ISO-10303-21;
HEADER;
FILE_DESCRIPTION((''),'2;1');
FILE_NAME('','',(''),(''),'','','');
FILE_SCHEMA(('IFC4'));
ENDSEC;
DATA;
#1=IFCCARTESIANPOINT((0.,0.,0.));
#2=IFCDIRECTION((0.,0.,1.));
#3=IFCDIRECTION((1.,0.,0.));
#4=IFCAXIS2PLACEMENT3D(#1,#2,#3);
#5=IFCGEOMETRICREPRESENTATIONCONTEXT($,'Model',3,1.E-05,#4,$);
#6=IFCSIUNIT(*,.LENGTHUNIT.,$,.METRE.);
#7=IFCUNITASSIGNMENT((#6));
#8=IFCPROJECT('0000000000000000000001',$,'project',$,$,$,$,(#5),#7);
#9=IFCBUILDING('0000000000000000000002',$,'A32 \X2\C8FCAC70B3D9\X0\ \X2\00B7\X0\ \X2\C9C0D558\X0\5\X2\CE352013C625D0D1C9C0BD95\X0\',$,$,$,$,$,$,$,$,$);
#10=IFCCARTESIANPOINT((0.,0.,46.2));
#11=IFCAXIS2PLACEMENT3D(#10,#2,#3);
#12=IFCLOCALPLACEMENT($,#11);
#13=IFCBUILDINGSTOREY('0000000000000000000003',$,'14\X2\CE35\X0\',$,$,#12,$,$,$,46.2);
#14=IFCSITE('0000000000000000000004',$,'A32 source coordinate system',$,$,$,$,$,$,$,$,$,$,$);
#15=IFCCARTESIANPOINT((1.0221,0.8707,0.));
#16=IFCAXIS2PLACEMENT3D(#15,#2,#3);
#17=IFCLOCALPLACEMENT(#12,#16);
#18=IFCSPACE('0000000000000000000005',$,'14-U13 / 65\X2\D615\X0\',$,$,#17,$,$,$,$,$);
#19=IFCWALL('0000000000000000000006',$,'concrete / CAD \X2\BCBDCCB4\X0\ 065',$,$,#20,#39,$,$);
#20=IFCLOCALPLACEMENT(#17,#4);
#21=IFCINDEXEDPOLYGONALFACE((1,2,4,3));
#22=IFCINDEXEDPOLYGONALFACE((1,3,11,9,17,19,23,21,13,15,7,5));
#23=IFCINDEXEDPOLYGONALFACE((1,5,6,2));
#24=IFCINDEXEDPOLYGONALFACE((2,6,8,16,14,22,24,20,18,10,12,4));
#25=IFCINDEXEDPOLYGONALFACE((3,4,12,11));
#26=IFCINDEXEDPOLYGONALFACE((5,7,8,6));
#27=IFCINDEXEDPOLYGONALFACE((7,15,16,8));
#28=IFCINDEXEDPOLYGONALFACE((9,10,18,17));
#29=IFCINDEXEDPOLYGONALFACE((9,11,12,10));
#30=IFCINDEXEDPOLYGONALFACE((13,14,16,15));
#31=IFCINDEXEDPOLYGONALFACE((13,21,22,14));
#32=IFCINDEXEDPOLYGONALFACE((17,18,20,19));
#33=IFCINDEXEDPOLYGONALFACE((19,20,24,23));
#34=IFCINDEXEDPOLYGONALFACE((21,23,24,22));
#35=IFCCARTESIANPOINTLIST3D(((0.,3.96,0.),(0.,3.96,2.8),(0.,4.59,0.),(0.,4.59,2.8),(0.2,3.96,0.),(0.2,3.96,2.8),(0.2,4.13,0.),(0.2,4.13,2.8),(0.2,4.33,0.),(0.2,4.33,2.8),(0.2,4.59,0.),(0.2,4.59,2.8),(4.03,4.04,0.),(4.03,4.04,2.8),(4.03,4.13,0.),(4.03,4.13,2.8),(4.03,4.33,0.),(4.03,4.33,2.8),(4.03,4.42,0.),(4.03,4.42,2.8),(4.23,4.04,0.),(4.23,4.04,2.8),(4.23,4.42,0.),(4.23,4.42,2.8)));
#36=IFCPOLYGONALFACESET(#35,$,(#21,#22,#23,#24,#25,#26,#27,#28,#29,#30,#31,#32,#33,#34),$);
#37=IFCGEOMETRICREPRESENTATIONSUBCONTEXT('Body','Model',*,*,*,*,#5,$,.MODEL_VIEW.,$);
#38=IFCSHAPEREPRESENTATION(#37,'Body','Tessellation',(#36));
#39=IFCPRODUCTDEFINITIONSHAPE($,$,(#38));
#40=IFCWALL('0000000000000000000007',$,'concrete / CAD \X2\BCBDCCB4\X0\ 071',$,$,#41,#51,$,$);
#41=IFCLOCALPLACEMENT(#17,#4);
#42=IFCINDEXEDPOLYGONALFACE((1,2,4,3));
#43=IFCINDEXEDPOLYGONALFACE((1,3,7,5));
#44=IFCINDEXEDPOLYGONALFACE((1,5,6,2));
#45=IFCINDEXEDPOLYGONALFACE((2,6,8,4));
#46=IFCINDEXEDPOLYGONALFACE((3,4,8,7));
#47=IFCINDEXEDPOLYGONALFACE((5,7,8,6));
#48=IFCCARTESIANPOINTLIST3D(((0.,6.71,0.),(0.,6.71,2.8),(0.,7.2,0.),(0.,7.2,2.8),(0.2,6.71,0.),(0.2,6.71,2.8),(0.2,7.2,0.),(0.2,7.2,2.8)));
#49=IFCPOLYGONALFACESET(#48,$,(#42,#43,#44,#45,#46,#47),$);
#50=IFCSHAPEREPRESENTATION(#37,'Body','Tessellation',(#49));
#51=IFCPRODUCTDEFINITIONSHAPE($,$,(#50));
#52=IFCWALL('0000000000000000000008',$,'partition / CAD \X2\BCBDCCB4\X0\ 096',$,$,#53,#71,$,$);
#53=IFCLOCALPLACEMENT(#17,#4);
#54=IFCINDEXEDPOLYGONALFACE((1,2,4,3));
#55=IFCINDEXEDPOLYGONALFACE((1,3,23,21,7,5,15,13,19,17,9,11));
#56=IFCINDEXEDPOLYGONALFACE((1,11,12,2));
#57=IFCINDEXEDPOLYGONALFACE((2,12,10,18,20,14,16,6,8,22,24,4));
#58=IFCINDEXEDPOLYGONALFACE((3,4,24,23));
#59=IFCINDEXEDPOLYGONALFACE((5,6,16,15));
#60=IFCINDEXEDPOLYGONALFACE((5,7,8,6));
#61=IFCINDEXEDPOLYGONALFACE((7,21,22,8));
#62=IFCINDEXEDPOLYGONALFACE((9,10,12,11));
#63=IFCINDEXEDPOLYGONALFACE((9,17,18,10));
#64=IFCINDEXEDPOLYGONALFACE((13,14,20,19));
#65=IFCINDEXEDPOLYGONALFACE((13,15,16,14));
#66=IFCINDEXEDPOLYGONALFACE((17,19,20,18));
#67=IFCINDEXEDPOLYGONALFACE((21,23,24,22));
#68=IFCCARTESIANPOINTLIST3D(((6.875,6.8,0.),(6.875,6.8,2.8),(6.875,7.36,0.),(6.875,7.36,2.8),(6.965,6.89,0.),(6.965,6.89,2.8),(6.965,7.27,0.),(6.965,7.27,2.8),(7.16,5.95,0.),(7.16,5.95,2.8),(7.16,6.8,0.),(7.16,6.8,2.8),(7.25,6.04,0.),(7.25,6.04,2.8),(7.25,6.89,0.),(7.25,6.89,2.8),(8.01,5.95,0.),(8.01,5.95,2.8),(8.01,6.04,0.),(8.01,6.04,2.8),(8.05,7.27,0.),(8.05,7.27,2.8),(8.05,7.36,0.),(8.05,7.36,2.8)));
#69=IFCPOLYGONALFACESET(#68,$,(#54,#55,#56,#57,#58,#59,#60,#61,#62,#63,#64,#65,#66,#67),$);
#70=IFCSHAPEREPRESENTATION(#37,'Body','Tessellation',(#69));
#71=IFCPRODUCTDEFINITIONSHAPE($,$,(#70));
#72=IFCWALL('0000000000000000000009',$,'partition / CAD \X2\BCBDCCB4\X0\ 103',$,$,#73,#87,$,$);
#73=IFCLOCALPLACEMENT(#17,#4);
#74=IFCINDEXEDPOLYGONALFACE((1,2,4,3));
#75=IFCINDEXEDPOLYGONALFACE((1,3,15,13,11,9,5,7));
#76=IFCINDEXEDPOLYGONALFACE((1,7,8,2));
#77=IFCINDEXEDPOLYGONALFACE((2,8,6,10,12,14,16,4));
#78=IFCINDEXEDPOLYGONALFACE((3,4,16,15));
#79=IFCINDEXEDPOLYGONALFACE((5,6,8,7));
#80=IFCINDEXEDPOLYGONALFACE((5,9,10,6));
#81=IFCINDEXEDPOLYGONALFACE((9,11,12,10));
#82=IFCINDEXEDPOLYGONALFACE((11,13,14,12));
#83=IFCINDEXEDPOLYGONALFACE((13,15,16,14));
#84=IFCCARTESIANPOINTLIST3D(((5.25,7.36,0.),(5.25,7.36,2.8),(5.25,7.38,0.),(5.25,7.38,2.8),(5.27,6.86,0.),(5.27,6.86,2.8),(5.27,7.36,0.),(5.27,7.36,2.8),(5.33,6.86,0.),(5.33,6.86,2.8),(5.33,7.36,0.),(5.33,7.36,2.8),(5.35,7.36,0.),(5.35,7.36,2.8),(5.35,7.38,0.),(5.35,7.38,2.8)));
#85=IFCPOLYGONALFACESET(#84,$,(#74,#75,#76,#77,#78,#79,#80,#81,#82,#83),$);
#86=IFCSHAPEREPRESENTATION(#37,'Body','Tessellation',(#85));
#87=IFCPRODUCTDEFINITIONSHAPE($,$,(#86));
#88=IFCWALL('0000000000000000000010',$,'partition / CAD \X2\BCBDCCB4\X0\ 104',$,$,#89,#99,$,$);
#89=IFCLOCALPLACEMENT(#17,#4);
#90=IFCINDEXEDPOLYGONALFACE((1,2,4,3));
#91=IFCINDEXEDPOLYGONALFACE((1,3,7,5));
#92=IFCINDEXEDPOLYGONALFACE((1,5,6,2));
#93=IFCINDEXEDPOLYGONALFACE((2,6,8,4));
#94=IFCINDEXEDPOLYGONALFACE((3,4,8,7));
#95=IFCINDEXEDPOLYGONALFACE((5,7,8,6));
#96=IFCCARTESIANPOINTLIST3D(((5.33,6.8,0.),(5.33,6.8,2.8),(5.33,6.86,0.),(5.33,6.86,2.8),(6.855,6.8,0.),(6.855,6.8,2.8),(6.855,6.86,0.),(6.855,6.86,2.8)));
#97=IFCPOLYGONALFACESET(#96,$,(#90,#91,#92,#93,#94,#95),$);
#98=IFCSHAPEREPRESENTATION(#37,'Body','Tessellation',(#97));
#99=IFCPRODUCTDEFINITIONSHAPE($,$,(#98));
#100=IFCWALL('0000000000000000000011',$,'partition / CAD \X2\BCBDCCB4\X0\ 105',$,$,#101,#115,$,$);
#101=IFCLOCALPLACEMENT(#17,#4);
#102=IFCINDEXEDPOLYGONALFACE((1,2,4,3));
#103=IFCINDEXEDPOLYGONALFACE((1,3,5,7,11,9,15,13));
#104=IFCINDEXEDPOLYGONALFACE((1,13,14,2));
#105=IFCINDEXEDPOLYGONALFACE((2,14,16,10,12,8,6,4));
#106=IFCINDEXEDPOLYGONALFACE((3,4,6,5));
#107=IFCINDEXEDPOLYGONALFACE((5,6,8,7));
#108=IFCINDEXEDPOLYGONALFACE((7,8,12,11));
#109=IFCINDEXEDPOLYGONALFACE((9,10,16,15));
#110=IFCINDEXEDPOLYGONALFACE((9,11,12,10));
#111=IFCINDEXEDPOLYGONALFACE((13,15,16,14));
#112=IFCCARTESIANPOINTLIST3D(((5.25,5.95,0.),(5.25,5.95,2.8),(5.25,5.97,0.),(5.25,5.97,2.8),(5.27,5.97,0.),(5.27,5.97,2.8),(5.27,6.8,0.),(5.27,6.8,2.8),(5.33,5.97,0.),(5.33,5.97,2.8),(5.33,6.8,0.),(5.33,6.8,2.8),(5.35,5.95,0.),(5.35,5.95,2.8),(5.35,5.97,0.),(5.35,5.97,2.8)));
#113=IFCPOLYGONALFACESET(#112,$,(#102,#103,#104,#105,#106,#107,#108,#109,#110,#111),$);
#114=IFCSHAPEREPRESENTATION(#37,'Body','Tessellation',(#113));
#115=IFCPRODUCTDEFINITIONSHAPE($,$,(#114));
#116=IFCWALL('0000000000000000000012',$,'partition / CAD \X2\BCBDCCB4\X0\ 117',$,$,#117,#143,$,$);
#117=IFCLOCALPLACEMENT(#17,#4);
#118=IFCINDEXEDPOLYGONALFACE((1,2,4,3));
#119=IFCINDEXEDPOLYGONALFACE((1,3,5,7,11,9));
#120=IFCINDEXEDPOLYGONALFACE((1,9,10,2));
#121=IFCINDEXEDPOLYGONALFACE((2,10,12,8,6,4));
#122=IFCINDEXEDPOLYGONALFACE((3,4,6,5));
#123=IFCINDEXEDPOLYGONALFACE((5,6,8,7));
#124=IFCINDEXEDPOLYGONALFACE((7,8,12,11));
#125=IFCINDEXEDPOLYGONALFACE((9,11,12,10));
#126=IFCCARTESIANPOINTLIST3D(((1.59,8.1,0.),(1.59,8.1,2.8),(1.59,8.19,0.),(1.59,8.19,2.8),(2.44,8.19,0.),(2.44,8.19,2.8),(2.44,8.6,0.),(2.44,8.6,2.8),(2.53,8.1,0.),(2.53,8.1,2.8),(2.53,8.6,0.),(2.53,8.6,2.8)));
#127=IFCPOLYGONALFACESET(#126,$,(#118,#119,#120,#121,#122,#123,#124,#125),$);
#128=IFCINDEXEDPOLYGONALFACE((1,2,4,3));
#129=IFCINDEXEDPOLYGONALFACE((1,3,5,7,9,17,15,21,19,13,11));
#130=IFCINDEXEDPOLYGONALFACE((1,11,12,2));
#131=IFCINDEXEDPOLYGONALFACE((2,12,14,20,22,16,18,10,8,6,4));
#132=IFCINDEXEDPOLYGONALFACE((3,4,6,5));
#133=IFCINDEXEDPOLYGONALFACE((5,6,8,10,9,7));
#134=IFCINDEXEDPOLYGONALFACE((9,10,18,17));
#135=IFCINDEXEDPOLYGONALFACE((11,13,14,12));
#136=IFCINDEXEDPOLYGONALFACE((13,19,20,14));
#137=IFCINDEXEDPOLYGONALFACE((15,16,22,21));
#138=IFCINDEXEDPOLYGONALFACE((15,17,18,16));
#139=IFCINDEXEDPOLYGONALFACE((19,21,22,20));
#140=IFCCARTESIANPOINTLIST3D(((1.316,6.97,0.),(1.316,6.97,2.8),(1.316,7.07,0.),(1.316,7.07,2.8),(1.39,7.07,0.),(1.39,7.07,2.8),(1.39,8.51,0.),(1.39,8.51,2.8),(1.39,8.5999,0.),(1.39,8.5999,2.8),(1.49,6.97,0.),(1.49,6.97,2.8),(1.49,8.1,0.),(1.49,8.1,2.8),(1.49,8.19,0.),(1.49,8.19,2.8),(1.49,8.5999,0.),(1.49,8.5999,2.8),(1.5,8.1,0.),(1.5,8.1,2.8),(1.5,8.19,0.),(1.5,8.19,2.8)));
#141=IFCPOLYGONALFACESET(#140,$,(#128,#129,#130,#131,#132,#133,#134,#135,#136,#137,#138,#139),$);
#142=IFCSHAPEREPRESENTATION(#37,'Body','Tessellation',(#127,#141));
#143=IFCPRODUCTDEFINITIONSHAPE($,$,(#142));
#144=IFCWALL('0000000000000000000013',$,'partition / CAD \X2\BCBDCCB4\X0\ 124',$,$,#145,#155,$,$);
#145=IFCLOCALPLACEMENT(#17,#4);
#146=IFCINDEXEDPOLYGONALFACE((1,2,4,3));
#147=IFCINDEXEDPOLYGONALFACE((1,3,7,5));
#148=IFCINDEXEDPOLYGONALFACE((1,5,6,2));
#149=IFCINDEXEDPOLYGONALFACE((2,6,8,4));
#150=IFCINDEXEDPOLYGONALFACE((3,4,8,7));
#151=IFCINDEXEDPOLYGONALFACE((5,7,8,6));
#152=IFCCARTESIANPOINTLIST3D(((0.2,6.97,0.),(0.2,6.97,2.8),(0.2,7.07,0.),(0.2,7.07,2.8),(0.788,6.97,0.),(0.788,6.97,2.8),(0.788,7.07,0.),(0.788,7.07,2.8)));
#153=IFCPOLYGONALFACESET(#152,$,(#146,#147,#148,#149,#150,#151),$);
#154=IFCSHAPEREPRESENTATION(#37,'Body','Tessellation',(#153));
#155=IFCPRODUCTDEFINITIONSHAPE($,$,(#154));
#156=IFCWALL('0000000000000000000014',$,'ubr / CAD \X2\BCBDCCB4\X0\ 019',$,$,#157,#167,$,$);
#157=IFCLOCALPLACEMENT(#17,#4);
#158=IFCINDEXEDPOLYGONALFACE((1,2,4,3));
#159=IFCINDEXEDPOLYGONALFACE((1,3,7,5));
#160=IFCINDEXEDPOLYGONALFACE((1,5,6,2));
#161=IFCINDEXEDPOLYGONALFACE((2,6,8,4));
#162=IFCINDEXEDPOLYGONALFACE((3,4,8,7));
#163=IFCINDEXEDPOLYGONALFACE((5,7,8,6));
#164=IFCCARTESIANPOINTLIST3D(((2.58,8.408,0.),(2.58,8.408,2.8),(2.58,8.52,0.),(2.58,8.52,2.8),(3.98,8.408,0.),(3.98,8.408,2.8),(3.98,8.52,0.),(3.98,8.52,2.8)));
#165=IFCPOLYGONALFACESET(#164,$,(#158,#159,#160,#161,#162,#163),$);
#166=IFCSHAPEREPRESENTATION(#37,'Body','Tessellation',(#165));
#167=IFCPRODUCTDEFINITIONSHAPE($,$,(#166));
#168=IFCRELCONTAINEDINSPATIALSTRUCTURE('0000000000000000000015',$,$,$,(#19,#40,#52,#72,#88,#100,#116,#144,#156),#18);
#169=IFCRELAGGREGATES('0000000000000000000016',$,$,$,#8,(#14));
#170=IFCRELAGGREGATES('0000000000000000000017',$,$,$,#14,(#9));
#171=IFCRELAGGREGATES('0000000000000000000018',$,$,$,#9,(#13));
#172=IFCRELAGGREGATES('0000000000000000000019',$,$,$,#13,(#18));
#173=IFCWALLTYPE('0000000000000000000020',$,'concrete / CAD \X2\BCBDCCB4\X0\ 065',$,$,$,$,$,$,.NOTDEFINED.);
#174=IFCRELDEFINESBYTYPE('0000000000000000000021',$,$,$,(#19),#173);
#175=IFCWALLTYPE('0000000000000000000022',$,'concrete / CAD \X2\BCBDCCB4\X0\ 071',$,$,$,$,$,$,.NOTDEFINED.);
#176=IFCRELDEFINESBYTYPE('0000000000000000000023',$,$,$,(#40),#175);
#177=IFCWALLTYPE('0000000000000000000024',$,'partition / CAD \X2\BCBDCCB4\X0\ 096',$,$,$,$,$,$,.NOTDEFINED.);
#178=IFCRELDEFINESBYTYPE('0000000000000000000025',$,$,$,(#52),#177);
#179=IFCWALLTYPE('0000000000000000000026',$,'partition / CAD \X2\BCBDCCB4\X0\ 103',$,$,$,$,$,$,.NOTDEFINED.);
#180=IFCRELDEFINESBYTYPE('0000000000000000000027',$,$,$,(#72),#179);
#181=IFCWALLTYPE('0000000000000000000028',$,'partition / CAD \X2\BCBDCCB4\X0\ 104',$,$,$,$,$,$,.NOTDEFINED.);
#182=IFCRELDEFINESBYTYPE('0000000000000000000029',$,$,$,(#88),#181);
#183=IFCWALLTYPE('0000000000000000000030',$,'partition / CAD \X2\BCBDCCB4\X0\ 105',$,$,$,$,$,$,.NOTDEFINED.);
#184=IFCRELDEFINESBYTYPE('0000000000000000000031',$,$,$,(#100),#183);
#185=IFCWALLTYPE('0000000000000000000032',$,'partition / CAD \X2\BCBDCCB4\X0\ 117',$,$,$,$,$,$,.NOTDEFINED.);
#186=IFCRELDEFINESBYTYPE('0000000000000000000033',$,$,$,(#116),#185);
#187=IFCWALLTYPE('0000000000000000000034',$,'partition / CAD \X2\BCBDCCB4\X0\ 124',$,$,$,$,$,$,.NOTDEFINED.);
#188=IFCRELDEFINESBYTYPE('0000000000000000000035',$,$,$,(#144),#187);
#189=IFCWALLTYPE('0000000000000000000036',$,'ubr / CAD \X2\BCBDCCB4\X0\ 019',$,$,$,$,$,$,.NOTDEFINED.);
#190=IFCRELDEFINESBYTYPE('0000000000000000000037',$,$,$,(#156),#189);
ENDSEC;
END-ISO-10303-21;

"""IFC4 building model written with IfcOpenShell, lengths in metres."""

from ifc_helpers import new_model, si_unit, frame, origin, origin_with_axes, place, context, subcontext, project, spatial, polyline, outline, extrude, source, transform, mapped, type_object, type_shapes, element, save


model = new_model("IFC4")

# Units and contexts
model_context = context("Model", 3, precision=1e-05, world=origin_with_axes())
body_context = subcontext(model_context, "Body", "Model", "MODEL_VIEW")
ifc_project = project(units=[si_unit("LENGTHUNIT", "METRE")], contexts=[model_context])

# Site, building, storey, space
storey_placement = place(None, frame((0.0, 0.0, 46.2), z_axis=(0.0, 0.0, 1.0), x_axis=(1.0, 0.0, 0.0)))
space_placement = place(storey_placement, frame((1.0221, 0.8707, 0.0), z_axis=(0.0, 0.0, 1.0), x_axis=(1.0, 0.0, 0.0)))
site = spatial("IfcSite", under=ifc_project, Name="A32 source coordinate system")
building = spatial("IfcBuilding", under=site, Name="A32 주거동 · 지하5층–옥탑지붕")
storey = spatial("IfcBuildingStorey", under=building, at=storey_placement, Name="14층", Elevation=46.2)
space = spatial("IfcSpace", under=storey, at=space_placement, Name="14-U13 / 65형")

# Walls
wall_type_1 = type_object("IfcWallType", Name="concrete / CAD 벽체 065", PredefinedType="NOTDEFINED")
shared_shape_1 = source(origin(), body_context, "Body", "SweptSolid", [
    extrude(outline(polyline([(0.2, 4.59), (0.2, 4.33), (4.03, 4.33), (4.03, 4.42), (4.23, 4.42), (4.23, 4.04), (4.03, 4.04), (4.03, 4.13), (0.2, 4.13), (0.2, 3.96), (0.0, 3.96), (0.0, 4.59), (0.2, 4.59)])), origin(), (0.0, 0.0, 1.0), 2.8),
])
type_shapes(wall_type_1, [shared_shape_1])
wall_1_placement = place(space_placement, origin_with_axes())
element("IfcWall", 1, at=wall_1_placement, inside=space, type_object=wall_type_1, Name="concrete / CAD 벽체 065", context=body_context, shape_type="MappedRepresentation", body=[
    mapped(shared_shape_1, transform((0.0, 0.0, 0.0), scale=1.0)),
])
wall_type_2 = type_object("IfcWallType", Name="concrete / CAD 벽체 071", PredefinedType="NOTDEFINED")
shared_shape_2 = source(origin(), body_context, "Body", "SweptSolid", [
    extrude(outline(polyline([(0.2, 6.71), (0.0, 6.71), (0.0, 7.2), (0.2, 7.2), (0.2, 6.71)])), origin(), (0.0, 0.0, 1.0), 2.8),
])
type_shapes(wall_type_2, [shared_shape_2])
wall_2_placement = place(space_placement, origin_with_axes())
element("IfcWall", 2, at=wall_2_placement, inside=space, type_object=wall_type_2, Name="concrete / CAD 벽체 071", context=body_context, shape_type="MappedRepresentation", body=[
    mapped(shared_shape_2, transform((0.0, 0.0, 0.0), scale=1.0)),
])
wall_type_3 = type_object("IfcWallType", Name="partition / CAD 벽체 096", PredefinedType="NOTDEFINED")
shared_shape_3 = source(origin(), body_context, "Body", "SweptSolid", [
    extrude(outline(polyline([(7.25, 6.04), (8.01, 6.04), (8.01, 5.95), (7.16, 5.95), (7.16, 6.8), (6.875, 6.8), (6.875, 7.36), (8.05, 7.36), (8.05, 7.27), (6.965, 7.27), (6.965, 6.89), (7.25, 6.89), (7.25, 6.04)])), origin(), (0.0, 0.0, 1.0), 2.8),
])
type_shapes(wall_type_3, [shared_shape_3])
wall_3_placement = place(space_placement, origin_with_axes())
element("IfcWall", 3, at=wall_3_placement, inside=space, type_object=wall_type_3, Name="partition / CAD 벽체 096", context=body_context, shape_type="MappedRepresentation", body=[
    mapped(shared_shape_3, transform((0.0, 0.0, 0.0), scale=1.0)),
])
wall_type_4 = type_object("IfcWallType", Name="partition / CAD 벽체 103", PredefinedType="NOTDEFINED")
shared_shape_4 = source(origin(), body_context, "Body", "SweptSolid", [
    extrude(outline(polyline([(5.27, 7.36), (5.25, 7.36), (5.25, 7.38), (5.35, 7.38), (5.35, 7.36), (5.33, 7.36), (5.33, 6.86), (5.27, 6.86), (5.27, 7.36)])), origin(), (0.0, 0.0, 1.0), 2.8),
])
type_shapes(wall_type_4, [shared_shape_4])
wall_4_placement = place(space_placement, origin_with_axes())
element("IfcWall", 4, at=wall_4_placement, inside=space, type_object=wall_type_4, Name="partition / CAD 벽체 103", context=body_context, shape_type="MappedRepresentation", body=[
    mapped(shared_shape_4, transform((0.0, 0.0, 0.0), scale=1.0)),
])
wall_type_5 = type_object("IfcWallType", Name="partition / CAD 벽체 104", PredefinedType="NOTDEFINED")
shared_shape_5 = source(origin(), body_context, "Body", "SweptSolid", [
    extrude(outline(polyline([(6.855, 6.86), (6.855, 6.8), (5.33, 6.8), (5.33, 6.86), (6.855, 6.86)])), origin(), (0.0, 0.0, 1.0), 2.8),
])
type_shapes(wall_type_5, [shared_shape_5])
wall_5_placement = place(space_placement, origin_with_axes())
element("IfcWall", 5, at=wall_5_placement, inside=space, type_object=wall_type_5, Name="partition / CAD 벽체 104", context=body_context, shape_type="MappedRepresentation", body=[
    mapped(shared_shape_5, transform((0.0, 0.0, 0.0), scale=1.0)),
])
wall_type_6 = type_object("IfcWallType", Name="partition / CAD 벽체 105", PredefinedType="NOTDEFINED")
shared_shape_6 = source(origin(), body_context, "Body", "SweptSolid", [
    extrude(outline(polyline([(5.25, 5.97), (5.27, 5.97), (5.27, 6.8), (5.33, 6.8), (5.33, 5.97), (5.35, 5.97), (5.35, 5.95), (5.25, 5.95), (5.25, 5.97)])), origin(), (0.0, 0.0, 1.0), 2.8),
])
type_shapes(wall_type_6, [shared_shape_6])
wall_6_placement = place(space_placement, origin_with_axes())
element("IfcWall", 6, at=wall_6_placement, inside=space, type_object=wall_type_6, Name="partition / CAD 벽체 105", context=body_context, shape_type="MappedRepresentation", body=[
    mapped(shared_shape_6, transform((0.0, 0.0, 0.0), scale=1.0)),
])
wall_type_7 = type_object("IfcWallType", Name="partition / CAD 벽체 117", PredefinedType="NOTDEFINED")
shared_shape_7 = source(origin(), body_context, "Body", "SweptSolid", [
    extrude(outline(polyline([(2.53, 8.1), (1.59, 8.1), (1.59, 8.19), (2.44, 8.19), (2.44, 8.6), (2.53, 8.6), (2.53, 8.1)])), origin(), (0.0, 0.0, 1.0), 2.8),
    extrude(outline(polyline([(1.49, 8.1), (1.49, 6.97), (1.316, 6.97), (1.316, 7.07), (1.39, 7.07), (1.39, 8.51), (1.39, 8.5999), (1.49, 8.5999), (1.49, 8.19), (1.5, 8.19), (1.5, 8.1), (1.49, 8.1)])), origin(), (0.0, 0.0, 1.0), 2.8),
])
type_shapes(wall_type_7, [shared_shape_7])
wall_7_placement = place(space_placement, origin_with_axes())
element("IfcWall", 7, at=wall_7_placement, inside=space, type_object=wall_type_7, Name="partition / CAD 벽체 117", context=body_context, shape_type="MappedRepresentation", body=[
    mapped(shared_shape_7, transform((0.0, 0.0, 0.0), scale=1.0)),
])
wall_type_8 = type_object("IfcWallType", Name="partition / CAD 벽체 124", PredefinedType="NOTDEFINED")
shared_shape_8 = source(origin(), body_context, "Body", "SweptSolid", [
    extrude(outline(polyline([(0.788, 7.07), (0.788, 6.97), (0.2, 6.97), (0.2, 7.07), (0.788, 7.07)])), origin(), (0.0, 0.0, 1.0), 2.8),
])
type_shapes(wall_type_8, [shared_shape_8])
wall_8_placement = place(space_placement, origin_with_axes())
element("IfcWall", 8, at=wall_8_placement, inside=space, type_object=wall_type_8, Name="partition / CAD 벽체 124", context=body_context, shape_type="MappedRepresentation", body=[
    mapped(shared_shape_8, transform((0.0, 0.0, 0.0), scale=1.0)),
])
wall_type_9 = type_object("IfcWallType", Name="ubr / CAD 벽체 019", PredefinedType="NOTDEFINED")
shared_shape_9 = source(origin(), body_context, "Body", "SweptSolid", [
    extrude(outline(polyline([(3.98, 8.408), (2.58, 8.408), (2.58, 8.52), (3.98, 8.52), (3.98, 8.408)])), origin(), (0.0, 0.0, 1.0), 2.8),
])
type_shapes(wall_type_9, [shared_shape_9])
wall_9_placement = place(space_placement, origin_with_axes())
element("IfcWall", 9, at=wall_9_placement, inside=space, type_object=wall_type_9, Name="ubr / CAD 벽체 019", context=body_context, shape_type="MappedRepresentation", body=[
    mapped(shared_shape_9, transform((0.0, 0.0, 0.0), scale=1.0)),
])

save(model, "model.ifc")
